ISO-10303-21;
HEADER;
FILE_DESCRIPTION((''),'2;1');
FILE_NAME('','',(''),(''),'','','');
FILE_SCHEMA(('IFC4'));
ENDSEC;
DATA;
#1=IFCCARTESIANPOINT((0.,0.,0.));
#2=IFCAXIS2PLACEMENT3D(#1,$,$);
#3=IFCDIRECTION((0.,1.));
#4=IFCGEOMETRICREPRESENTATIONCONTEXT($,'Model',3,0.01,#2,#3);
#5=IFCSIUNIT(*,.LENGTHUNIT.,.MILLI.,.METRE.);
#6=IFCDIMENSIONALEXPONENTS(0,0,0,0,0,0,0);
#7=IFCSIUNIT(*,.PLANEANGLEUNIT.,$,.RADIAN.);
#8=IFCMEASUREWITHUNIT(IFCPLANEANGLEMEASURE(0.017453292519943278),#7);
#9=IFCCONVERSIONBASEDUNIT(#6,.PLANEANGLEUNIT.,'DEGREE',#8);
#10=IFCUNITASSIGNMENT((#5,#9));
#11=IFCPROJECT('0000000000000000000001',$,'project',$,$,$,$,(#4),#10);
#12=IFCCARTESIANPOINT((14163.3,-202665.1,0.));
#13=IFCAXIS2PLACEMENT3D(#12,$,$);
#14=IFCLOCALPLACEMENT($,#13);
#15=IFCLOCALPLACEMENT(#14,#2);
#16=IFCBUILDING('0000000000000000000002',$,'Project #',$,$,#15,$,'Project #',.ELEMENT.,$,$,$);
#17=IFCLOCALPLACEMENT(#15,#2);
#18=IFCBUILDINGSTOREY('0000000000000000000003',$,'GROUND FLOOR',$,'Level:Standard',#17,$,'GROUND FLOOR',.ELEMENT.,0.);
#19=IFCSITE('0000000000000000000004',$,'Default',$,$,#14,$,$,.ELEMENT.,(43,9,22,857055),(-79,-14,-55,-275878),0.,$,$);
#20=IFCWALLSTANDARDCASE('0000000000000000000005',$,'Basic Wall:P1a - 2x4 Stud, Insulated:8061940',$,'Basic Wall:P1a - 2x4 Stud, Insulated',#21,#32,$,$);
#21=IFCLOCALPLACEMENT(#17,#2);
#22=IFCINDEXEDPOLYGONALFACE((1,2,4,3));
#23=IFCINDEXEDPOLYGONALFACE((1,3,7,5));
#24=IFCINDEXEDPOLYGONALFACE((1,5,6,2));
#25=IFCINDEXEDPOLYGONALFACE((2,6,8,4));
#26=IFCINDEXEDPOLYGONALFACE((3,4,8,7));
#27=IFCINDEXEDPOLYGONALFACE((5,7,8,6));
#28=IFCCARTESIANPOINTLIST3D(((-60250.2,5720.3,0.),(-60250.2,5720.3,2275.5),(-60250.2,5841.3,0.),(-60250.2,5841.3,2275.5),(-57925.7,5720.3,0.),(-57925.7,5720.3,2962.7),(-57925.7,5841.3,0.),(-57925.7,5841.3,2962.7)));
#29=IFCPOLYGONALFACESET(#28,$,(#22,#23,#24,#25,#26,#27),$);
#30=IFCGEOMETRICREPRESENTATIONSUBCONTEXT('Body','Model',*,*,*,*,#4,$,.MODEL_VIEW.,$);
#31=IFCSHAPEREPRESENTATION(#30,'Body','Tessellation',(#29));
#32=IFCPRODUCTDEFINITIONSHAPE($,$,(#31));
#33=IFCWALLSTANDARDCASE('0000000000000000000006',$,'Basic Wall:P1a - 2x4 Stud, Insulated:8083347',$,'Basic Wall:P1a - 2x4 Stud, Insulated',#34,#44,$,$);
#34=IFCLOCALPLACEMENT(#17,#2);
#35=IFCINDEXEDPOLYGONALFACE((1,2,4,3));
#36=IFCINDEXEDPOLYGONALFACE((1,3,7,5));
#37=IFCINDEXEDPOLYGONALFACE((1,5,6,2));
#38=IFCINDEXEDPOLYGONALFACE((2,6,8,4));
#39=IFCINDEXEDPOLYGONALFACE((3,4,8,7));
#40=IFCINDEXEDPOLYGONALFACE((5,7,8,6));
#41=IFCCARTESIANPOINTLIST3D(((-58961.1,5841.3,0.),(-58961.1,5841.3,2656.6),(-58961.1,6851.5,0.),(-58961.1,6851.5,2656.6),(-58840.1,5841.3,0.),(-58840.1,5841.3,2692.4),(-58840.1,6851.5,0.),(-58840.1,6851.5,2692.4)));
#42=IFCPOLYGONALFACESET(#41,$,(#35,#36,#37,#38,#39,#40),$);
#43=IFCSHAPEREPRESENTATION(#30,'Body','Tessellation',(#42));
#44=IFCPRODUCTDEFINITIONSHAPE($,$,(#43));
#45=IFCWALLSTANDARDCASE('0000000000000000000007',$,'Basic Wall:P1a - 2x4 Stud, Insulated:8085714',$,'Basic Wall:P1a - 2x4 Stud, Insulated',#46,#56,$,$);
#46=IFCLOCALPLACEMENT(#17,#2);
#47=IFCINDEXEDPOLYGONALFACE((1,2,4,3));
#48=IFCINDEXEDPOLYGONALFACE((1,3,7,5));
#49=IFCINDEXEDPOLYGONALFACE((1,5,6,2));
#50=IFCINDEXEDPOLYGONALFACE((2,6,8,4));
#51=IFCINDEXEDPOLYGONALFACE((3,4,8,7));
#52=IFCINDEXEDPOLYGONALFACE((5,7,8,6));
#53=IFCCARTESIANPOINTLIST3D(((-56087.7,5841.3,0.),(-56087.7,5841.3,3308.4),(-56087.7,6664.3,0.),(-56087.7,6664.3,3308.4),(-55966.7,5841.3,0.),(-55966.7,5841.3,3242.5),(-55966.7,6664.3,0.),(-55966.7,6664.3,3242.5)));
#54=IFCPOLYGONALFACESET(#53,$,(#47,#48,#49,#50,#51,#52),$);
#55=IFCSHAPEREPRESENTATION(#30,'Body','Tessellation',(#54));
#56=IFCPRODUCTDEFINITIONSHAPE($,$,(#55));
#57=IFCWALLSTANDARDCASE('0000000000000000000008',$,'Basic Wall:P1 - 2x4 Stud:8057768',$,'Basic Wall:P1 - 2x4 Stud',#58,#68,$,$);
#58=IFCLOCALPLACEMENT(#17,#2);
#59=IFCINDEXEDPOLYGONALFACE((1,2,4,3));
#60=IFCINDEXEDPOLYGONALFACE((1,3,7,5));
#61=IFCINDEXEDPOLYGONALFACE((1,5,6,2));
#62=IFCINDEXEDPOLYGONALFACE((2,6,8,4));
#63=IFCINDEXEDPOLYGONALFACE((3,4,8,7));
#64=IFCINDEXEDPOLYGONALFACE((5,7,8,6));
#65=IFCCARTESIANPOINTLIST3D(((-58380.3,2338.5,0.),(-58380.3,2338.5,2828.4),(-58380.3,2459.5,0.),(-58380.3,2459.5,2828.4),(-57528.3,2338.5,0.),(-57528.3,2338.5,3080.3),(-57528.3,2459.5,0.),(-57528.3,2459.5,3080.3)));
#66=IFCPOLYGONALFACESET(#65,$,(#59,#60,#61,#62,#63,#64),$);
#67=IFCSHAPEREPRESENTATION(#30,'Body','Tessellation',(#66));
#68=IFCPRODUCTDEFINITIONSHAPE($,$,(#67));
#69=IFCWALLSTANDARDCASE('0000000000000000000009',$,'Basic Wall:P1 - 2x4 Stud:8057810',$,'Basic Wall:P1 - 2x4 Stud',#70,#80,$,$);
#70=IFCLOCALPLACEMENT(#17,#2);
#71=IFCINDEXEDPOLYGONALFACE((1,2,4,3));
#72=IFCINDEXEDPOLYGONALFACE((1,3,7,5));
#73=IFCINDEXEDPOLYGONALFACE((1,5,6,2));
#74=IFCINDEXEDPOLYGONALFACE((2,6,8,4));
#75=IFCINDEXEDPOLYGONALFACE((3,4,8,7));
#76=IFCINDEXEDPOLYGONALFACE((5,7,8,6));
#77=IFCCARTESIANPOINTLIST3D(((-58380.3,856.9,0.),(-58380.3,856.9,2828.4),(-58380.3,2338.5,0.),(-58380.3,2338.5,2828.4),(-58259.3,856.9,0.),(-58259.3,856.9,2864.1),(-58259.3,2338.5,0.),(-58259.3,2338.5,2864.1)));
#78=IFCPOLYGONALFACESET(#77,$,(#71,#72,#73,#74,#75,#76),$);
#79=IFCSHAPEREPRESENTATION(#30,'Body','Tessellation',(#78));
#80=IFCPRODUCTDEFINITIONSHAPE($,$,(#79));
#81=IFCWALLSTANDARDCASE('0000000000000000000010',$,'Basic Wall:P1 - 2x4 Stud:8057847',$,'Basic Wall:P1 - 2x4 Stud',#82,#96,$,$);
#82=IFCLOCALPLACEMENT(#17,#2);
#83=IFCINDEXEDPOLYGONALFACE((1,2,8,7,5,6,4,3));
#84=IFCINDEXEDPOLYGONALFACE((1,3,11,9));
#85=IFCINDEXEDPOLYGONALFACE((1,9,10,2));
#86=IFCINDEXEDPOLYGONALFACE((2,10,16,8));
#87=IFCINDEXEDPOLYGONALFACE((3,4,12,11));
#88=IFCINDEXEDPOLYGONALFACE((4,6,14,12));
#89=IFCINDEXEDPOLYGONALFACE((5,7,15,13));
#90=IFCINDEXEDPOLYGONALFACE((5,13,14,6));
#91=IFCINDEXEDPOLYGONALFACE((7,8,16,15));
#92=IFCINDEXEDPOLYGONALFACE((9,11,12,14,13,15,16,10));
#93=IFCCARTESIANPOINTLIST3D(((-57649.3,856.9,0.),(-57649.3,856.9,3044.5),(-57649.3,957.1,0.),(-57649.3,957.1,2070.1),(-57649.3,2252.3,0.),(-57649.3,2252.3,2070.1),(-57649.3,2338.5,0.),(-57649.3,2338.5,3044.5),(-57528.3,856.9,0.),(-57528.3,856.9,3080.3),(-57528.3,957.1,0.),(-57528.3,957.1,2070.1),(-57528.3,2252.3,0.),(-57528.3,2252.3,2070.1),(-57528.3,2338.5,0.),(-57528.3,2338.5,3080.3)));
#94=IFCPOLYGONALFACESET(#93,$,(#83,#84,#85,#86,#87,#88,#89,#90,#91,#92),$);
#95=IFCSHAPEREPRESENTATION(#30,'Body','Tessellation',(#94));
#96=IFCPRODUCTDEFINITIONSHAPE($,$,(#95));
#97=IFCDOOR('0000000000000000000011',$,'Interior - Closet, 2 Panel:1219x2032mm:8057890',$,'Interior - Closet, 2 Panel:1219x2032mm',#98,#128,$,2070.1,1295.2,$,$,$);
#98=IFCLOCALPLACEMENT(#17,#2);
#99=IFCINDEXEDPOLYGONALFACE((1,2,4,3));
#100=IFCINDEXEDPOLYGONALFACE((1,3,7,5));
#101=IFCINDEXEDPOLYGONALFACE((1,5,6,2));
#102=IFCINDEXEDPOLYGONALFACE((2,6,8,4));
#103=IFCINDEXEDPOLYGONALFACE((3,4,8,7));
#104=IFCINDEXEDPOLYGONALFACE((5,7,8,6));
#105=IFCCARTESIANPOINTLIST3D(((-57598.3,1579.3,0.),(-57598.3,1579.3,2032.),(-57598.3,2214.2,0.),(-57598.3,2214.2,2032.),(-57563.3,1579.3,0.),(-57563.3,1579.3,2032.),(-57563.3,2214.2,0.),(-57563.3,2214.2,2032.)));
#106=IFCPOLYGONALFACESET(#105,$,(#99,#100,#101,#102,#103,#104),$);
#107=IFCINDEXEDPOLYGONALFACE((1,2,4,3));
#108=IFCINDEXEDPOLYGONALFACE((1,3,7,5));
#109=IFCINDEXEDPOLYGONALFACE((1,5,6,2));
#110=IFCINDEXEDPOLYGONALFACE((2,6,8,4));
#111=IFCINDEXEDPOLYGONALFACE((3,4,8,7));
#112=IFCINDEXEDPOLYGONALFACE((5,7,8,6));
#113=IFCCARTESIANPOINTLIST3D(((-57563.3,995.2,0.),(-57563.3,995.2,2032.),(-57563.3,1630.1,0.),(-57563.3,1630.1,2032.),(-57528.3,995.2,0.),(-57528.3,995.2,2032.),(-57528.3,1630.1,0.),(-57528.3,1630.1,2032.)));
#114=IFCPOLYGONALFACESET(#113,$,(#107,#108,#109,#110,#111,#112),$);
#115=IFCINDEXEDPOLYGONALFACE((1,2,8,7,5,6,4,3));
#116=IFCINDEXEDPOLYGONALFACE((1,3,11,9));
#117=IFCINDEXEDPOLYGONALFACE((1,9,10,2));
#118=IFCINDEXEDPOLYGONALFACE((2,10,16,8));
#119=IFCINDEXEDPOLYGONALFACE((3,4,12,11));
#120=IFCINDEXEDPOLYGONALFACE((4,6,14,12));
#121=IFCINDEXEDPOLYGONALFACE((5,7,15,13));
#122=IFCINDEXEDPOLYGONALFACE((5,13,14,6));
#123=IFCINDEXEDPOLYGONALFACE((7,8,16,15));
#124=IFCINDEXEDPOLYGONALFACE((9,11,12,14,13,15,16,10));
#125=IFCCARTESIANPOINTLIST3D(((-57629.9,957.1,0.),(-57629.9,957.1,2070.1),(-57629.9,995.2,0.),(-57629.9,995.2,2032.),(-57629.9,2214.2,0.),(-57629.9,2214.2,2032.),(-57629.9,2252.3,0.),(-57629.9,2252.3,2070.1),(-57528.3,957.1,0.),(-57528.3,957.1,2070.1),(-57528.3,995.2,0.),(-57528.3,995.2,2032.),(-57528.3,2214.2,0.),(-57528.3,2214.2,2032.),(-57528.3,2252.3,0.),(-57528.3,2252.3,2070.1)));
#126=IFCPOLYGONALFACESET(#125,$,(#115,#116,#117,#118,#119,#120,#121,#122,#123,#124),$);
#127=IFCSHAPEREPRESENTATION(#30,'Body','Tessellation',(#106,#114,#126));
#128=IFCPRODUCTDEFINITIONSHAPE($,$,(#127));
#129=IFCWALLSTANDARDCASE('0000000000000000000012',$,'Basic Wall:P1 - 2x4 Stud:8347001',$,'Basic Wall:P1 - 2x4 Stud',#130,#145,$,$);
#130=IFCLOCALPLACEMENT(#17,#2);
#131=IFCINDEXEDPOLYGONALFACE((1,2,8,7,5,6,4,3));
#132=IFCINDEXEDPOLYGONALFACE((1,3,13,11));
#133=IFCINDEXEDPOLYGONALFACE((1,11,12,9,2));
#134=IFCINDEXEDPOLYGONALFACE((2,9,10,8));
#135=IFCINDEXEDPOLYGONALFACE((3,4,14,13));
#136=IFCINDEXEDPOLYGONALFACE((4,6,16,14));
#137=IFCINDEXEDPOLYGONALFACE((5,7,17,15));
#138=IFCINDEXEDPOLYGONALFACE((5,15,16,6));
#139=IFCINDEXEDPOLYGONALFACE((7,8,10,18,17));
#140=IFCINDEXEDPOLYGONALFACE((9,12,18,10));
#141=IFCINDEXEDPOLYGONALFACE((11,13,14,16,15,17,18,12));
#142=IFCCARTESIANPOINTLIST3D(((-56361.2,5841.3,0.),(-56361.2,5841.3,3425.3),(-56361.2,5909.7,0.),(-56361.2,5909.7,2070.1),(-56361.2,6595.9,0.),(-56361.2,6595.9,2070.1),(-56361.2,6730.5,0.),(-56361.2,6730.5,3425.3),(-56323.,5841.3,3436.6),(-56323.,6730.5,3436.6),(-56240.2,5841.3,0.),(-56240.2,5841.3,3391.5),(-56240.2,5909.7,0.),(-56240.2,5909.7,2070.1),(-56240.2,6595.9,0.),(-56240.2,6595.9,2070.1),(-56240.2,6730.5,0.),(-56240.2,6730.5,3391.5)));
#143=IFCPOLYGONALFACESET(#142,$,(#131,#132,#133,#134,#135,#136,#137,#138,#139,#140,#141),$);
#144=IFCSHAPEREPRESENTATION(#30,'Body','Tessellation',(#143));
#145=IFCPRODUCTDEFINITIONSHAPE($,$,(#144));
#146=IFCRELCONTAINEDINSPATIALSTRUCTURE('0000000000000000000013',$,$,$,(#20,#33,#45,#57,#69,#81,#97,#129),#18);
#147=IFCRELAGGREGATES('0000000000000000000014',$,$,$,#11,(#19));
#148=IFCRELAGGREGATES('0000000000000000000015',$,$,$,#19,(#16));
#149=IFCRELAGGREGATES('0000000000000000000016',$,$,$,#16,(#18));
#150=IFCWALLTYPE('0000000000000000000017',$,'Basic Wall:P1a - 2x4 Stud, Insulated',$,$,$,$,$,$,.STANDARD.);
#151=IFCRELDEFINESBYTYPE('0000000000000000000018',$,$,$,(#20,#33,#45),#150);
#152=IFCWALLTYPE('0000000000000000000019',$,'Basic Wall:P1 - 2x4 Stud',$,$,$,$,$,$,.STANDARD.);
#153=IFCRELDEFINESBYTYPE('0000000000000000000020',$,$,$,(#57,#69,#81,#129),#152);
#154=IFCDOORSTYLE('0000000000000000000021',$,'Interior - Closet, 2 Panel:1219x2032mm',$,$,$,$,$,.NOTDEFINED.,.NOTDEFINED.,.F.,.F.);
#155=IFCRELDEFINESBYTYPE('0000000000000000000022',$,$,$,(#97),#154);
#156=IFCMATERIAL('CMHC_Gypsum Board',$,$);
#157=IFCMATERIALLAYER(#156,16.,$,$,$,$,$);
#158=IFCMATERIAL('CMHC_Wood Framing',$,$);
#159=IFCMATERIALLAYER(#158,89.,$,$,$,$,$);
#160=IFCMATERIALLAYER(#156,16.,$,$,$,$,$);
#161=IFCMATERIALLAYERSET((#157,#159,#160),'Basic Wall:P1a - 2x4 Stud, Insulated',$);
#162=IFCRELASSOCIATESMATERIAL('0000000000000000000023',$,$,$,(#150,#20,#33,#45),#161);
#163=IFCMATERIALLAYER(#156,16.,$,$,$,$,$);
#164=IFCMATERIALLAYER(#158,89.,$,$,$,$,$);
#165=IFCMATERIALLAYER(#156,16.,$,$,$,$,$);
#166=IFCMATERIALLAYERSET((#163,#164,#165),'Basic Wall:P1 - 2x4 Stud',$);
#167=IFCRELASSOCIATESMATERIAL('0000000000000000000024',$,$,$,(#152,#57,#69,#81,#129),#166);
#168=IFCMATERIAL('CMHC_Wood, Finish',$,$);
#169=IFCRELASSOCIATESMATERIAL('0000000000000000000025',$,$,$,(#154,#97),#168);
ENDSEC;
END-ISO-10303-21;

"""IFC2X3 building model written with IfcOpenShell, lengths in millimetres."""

from ifc_helpers import new_model, entity, si_unit, converted_unit, direction, frame, frame_2d, origin, origin_2d_with_axis, place, context, subcontext, project, spatial, polyline, rectangle, outline, extrude, clip, bounded_halfspace, source, transform, mapped, material, layer, layer_set, layer_usage, type_object, type_shapes, element, fill, save


model = new_model("IFC2X3")

# Units and contexts
model_context = context("Model", 3, precision=0.01, world=origin(), true_north=direction((0.0, 1.0)))
body_context = subcontext(model_context, "Body", "Model", "MODEL_VIEW")
ifc_project = project(units=[si_unit("LENGTHUNIT", "METRE", prefix="MILLI"), converted_unit("PLANEANGLEUNIT", "DEGREE", entity("IfcPlaneAngleMeasure", 0.017453292519943278), si_unit("PLANEANGLEUNIT", "RADIAN"), dimensions=[0, 0, 0, 0, 0, 0, 0])], contexts=[model_context])

# Site, building, storey
site_placement = place(None, frame((14163.3, -202665.1, 0.0)))
site = spatial("IfcSite", under=ifc_project, at=site_placement, Name="Default", CompositionType="ELEMENT", RefLatitude=(43, 9, 22, 857055), RefLongitude=(-79, -14, -55, -275878), RefElevation=0.0)
building_placement = place(site_placement, origin())
building = spatial("IfcBuilding", under=site, at=building_placement, Name="Project #", LongName="Project #", CompositionType="ELEMENT")
storey_placement = place(building_placement, origin())
storey = spatial("IfcBuildingStorey", under=building, at=storey_placement, Name="GROUND FLOOR", ObjectType="Level:Standard", LongName="GROUND FLOOR", CompositionType="ELEMENT", Elevation=0.0)

# Shared definitions
ifc_material_1 = material(Name="CMHC_Wood Framing")
ifc_material_2 = material(Name="CMHC_Gypsum Board")

# Shared definitions
ifc_layer_1 = layer(ifc_material_2, 16.0)
ifc_layer_2 = layer(ifc_material_1, 89.0)
ifc_layer_3 = layer(ifc_material_2, 16.0)
ifc_layer_set_1 = layer_set([ifc_layer_1, ifc_layer_2, ifc_layer_3], Name="Basic Wall:P1a - 2x4 Stud, Insulated")
wall_type_1 = type_object("IfcWallType", Name="Basic Wall:P1a - 2x4 Stud, Insulated", PredefinedType="STANDARD", material=ifc_layer_set_1)

# Shared definitions
ifc_material_3 = material(Name="CMHC_Wood, Finish")

# Walls
ifc_layer_usage_1 = layer_usage(ifc_layer_set_1, "AXIS2", "POSITIVE", -60.5)
wall_1_placement = place(storey_placement, frame((-57925.7, 5780.8, 0.0), z_axis=(0.0, 0.0, 1.0), x_axis=(-1.0, 0.0, 0.0)))
element("IfcWallStandardCase", 1, at=wall_1_placement, inside=storey, type_object=wall_type_1, material=ifc_layer_usage_1, Name="Basic Wall:P1a - 2x4 Stud, Insulated:8061940", ObjectType="Basic Wall:P1a - 2x4 Stud, Insulated", context=body_context, shape_type="Clipping", body=[
    clip(extrude(rectangle(XDim=2324.5, YDim=121.0, at=frame_2d((1162.2, 0.0), x_axis=(-1.0, 0.0))), origin(), (0.0, 0.0, 1.0), 2962.7), bounded_halfspace(frame((0.0, -60.5, 2962.7), z_axis=(0.283519, 0.0, 0.958967), x_axis=(0.0, 1.0, 0.0)), False, frame((0.0, -60.5, 2962.7)), polyline([(0.0, 0.0), (914.4, 0.0), (1035.4, 0.0), (2324.5, 0.0), (2324.5, 121.0), (2206.5, 121.0), (0.0, 121.0), (0.0, 0.0)]))),
])
ifc_layer_usage_2 = layer_usage(ifc_layer_set_1, "AXIS2", "POSITIVE", -60.5)
wall_2_placement = place(storey_placement, frame((-58900.6, 5841.3, 0.0), z_axis=(0.0, 0.0, 1.0), x_axis=(0.0, 1.0, 0.0)))
element("IfcWallStandardCase", 2, at=wall_2_placement, inside=storey, type_object=wall_type_1, material=ifc_layer_usage_2, Name="Basic Wall:P1a - 2x4 Stud, Insulated:8083347", ObjectType="Basic Wall:P1a - 2x4 Stud, Insulated", context=body_context, shape_type="Clipping", body=[
    clip(extrude(rectangle(XDim=1010.2, YDim=121.0, at=frame_2d((505.1, 0.0), x_axis=(-1.0, 0.0))), origin(), (0.0, 0.0, 1.0), 2692.4), bounded_halfspace(frame((0.0, -60.5, 2692.4), z_axis=(0.0, 0.283519, 0.958967), x_axis=(-1.0, 0.0, 0.0)), False, frame((0.0, -60.5, 2692.4)), polyline([(0.0, 0.0), (889.2, 0.0), (1010.2, 0.0), (1010.2, 121.0), (889.2, 121.0), (0.0, 121.0), (0.0, 0.0)]))),
])
ifc_layer_usage_3 = layer_usage(ifc_layer_set_1, "AXIS2", "POSITIVE", -60.5)
wall_3_placement = place(storey_placement, frame((-56027.2, 6664.3, 0.0), z_axis=(0.0, 0.0, 1.0), x_axis=(0.0, -1.0, 0.0)))
element("IfcWallStandardCase", 3, at=wall_3_placement, inside=storey, type_object=wall_type_1, material=ifc_layer_usage_3, Name="Basic Wall:P1a - 2x4 Stud, Insulated:8085714", ObjectType="Basic Wall:P1a - 2x4 Stud, Insulated", context=body_context, shape_type="Clipping", body=[
    clip(extrude(rectangle(XDim=823.0, YDim=121.0, at=frame_2d((411.5, 0.0), x_axis=(-1.0, 0.0))), origin(), (0.0, 0.0, 1.0), 3308.4), bounded_halfspace(frame((0.0, -60.5, 3308.4), z_axis=(0.0, 0.478352, 0.878168), x_axis=(-1.0, 0.0, 0.0)), False, frame((0.0, -60.5, 3308.4)), polyline([(0.0, 0.0), (823.0, 0.0), (823.0, 121.0), (0.0, 121.0), (0.0, 0.0)]))),
])
ifc_layer_4 = layer(ifc_material_2, 16.0)
ifc_layer_5 = layer(ifc_material_1, 89.0)
ifc_layer_6 = layer(ifc_material_2, 16.0)
ifc_layer_set_2 = layer_set([ifc_layer_4, ifc_layer_5, ifc_layer_6], Name="Basic Wall:P1 - 2x4 Stud")
ifc_layer_usage_4 = layer_usage(ifc_layer_set_2, "AXIS2", "POSITIVE", -60.5)
wall_type_2 = type_object("IfcWallType", Name="Basic Wall:P1 - 2x4 Stud", PredefinedType="STANDARD", material=ifc_layer_set_2)
wall_4_placement = place(storey_placement, frame((-57528.3, 2399.0, 0.0), z_axis=(0.0, 0.0, 1.0), x_axis=(-1.0, 0.0, 0.0)))
element("IfcWallStandardCase", 4, at=wall_4_placement, inside=storey, type_object=wall_type_2, material=ifc_layer_usage_4, Name="Basic Wall:P1 - 2x4 Stud:8057768", ObjectType="Basic Wall:P1 - 2x4 Stud", context=body_context, shape_type="Clipping", body=[
    clip(extrude(rectangle(XDim=852.0, YDim=121.0, at=frame_2d((426.0, 0.0), x_axis=(-1.0, 0.0))), origin(), (0.0, 0.0, 1.0), 3080.3), bounded_halfspace(frame((0.0, -60.5, 3080.3), z_axis=(0.283519, 0.0, 0.958967), x_axis=(0.0, 1.0, 0.0)), False, frame((0.0, -60.5, 3080.3)), polyline([(0.0, 0.0), (852.0, 0.0), (852.0, 121.0), (731.0, 121.0), (121.0, 121.0), (0.0, 121.0), (0.0, 0.0)]))),
])
ifc_layer_usage_5 = layer_usage(ifc_layer_set_2, "AXIS2", "POSITIVE", -60.5)
wall_5_placement = place(storey_placement, frame((-58319.8, 2338.5, 0.0), z_axis=(0.0, 0.0, 1.0), x_axis=(0.0, -1.0, 0.0)))
element("IfcWallStandardCase", 5, at=wall_5_placement, inside=storey, type_object=wall_type_2, material=ifc_layer_usage_5, Name="Basic Wall:P1 - 2x4 Stud:8057810", ObjectType="Basic Wall:P1 - 2x4 Stud", context=body_context, shape_type="Clipping", body=[
    clip(extrude(rectangle(XDim=1481.6, YDim=121.0, at=frame_2d((740.8, 0.0), x_axis=(-1.0, 0.0))), origin(), (0.0, 0.0, 1.0), 2864.1), bounded_halfspace(frame((0.0, -60.5, 2828.4), z_axis=(0.0, -0.283519, 0.958967), x_axis=(1.0, 0.0, 0.0)), False, frame((0.0, -60.5, 2828.4)), polyline([(0.0, 0.0), (1481.6, 0.0), (1481.6, 121.0), (0.0, 121.0), (0.0, 0.0)]))),
])

# Wall, opening, door
ifc_layer_usage_6 = layer_usage(ifc_layer_set_2, "AXIS2", "POSITIVE", -60.5)
wall_6_placement = place(storey_placement, frame((-57588.8, 856.9, 0.0), z_axis=(0.0, 0.0, 1.0), x_axis=(0.0, 1.0, 0.0)))
wall_6 = element("IfcWallStandardCase", 6, at=wall_6_placement, inside=storey, type_object=wall_type_2, material=ifc_layer_usage_6, Name="Basic Wall:P1 - 2x4 Stud:8057847", ObjectType="Basic Wall:P1 - 2x4 Stud", context=body_context, shape_type="Clipping", body=[
    clip(extrude(rectangle(XDim=1481.6, YDim=121.0, at=frame_2d((740.8, 0.0), x_axis=(1.0, 0.0))), origin(), (0.0, 0.0, 1.0), 3080.3), bounded_halfspace(frame((0.0, -60.5, 3080.3), z_axis=(0.0, 0.283519, 0.958967), x_axis=(-1.0, 0.0, 0.0)), False, frame((0.0, -60.5, 3080.3)), polyline([(0.0, 0.0), (1481.6, 0.0), (1481.6, 121.0), (0.0, 121.0), (0.0, 0.0)]))),
])
opening_1_placement = place(wall_6_placement, frame((1395.4, 60.5, 0.0)))
opening_1 = element("IfcOpeningElement", 7, at=opening_1_placement, cuts=wall_6, ObjectType="Opening", context=body_context, shape_type="SweptSolid", body=[
    extrude(rectangle(XDim=1295.2, YDim=2070.1, at=frame_2d((1035.0, 647.6), x_axis=(0.0, -1.0))), frame((0.0, 0.0, 0.0), z_axis=(0.0, -1.0, 0.0), x_axis=(0.0, 0.0, 1.0)), (0.0, 0.0, 1.0), 121.0),
])
door_style_1 = type_object("IfcDoorStyle", Name="Interior - Closet, 2 Panel:1219x2032mm", ConstructionType="NOTDEFINED", OperationType="NOTDEFINED", ParameterTakesPrecedence=False, Sizeable=False, material=ifc_material_3)
shared_shape_1 = source(origin(), body_context, "Body", "SweptSolid", [
    extrude(rectangle(XDim=634.9, YDim=35.0, at=origin_2d_with_axis()), frame((355.6, 68.5, 0.0)), (0.0, 0.0, 1.0), 2032.0),
    extrude(rectangle(XDim=634.9, YDim=35.0, at=frame_2d((0.0, 0.0), x_axis=(1.0, 0.0))), frame((939.7, 103.5, 0.0)), (0.0, 0.0, 1.0), 2032.0),
    extrude(outline(polyline([(609.5, -1025.5), (647.6, -1025.5), (647.6, 1044.6), (-647.6, 1044.6), (-647.6, -1025.5), (-609.5, -1025.5), (-609.5, 1006.5), (609.5, 1006.5), (609.5, -1025.5)])), frame((647.6, 121.0, 1025.5), z_axis=(0.0, -1.0, 0.0), x_axis=(1.0, 0.0, 0.0)), (0.0, 0.0, 1.0), 101.6),
])
type_shapes(door_style_1, [shared_shape_1])
door_1_placement = place(opening_1_placement, frame((0.0, 0.0, 0.0), z_axis=(0.0, 0.0, 1.0), x_axis=(-1.0, 0.0, 0.0)))
door_1 = element("IfcDoor", 8, at=door_1_placement, inside=storey, type_object=door_style_1, material=ifc_material_3, Name="Interior - Closet, 2 Panel:1219x2032mm:8057890", ObjectType="Interior - Closet, 2 Panel:1219x2032mm", OverallHeight=2070.1, OverallWidth=1295.2, context=body_context, shape_type="MappedRepresentation", body=[
    mapped(shared_shape_1, transform((0.0, 0.0, 0.0), scale=1.0)),
])
fill(opening_1, door_1)

# Wall, opening
ifc_layer_usage_7 = layer_usage(ifc_layer_set_2, "AXIS2", "POSITIVE", -60.5)
wall_7_placement = place(storey_placement, frame((-56300.7, 5841.3, 0.0), z_axis=(0.0, 0.0, 1.0), x_axis=(0.0, 1.0, 0.0)))
wall_7 = element("IfcWallStandardCase", 9, at=wall_7_placement, inside=storey, type_object=wall_type_2, material=ifc_layer_usage_7, Name="Basic Wall:P1 - 2x4 Stud:8347001", ObjectType="Basic Wall:P1 - 2x4 Stud", context=body_context, shape_type="Clipping", body=[
    clip(clip(clip(extrude(rectangle(XDim=889.2, YDim=121.0, at=frame_2d((444.6, 0.0), x_axis=(-1.0, 0.0))), origin(), (0.0, 0.0, 1.0), 3436.6), bounded_halfspace(frame((0.0, 22.3, 3436.6), z_axis=(0.0, -0.478352, 0.878168), x_axis=(1.0, 0.0, 0.0)), False, frame((0.0, 22.3, 3436.6)), polyline([(0.0, 0.0), (0.0, -82.8), (823.0, -82.8), (889.2, -82.8), (889.2, 0.0), (0.0, 0.0)]))), bounded_halfspace(frame((0.0, 60.5, 3425.3), z_axis=(0.0, 0.283519, 0.958967), x_axis=(-1.0, 0.0, 0.0)), False, frame((0.0, 60.5, 3425.3)), polyline([(0.0, 0.0), (0.0, -38.2), (889.2, -38.2), (889.2, 0.0), (0.0, 0.0)]))), bounded_halfspace(frame((889.2, -60.5, 3391.5), z_axis=(-1.0, 0.0, 0.0), x_axis=(0.0, -1.0, 0.0)), True, frame((889.2, -60.5, 3391.5), z_axis=(-1.0, 0.0, 0.0), x_axis=(0.0, -1.0, 0.0)), polyline([(0.0, 0.0), (-82.8, 45.1), (-121.0, 33.8), (-121.0, -3391.5), (0.0, -3391.5), (0.0, 0.0)]))),
])
opening_2_placement = place(wall_7_placement, frame((68.4, -60.5, 0.0)))
element("IfcOpeningElement", 10, at=opening_2_placement, cuts=wall_7, ObjectType="Opening", context=body_context, shape_type="SweptSolid", body=[
    extrude(rectangle(XDim=686.2, YDim=2070.1, at=frame_2d((1035.1, 343.1), x_axis=(0.0, -1.0))), frame((0.0, 0.0, 0.0), z_axis=(0.0, 1.0, 0.0), x_axis=(0.0, 0.0, 1.0)), (0.0, 0.0, 1.0), 121.0),
])

save(model, "model.ifc")
